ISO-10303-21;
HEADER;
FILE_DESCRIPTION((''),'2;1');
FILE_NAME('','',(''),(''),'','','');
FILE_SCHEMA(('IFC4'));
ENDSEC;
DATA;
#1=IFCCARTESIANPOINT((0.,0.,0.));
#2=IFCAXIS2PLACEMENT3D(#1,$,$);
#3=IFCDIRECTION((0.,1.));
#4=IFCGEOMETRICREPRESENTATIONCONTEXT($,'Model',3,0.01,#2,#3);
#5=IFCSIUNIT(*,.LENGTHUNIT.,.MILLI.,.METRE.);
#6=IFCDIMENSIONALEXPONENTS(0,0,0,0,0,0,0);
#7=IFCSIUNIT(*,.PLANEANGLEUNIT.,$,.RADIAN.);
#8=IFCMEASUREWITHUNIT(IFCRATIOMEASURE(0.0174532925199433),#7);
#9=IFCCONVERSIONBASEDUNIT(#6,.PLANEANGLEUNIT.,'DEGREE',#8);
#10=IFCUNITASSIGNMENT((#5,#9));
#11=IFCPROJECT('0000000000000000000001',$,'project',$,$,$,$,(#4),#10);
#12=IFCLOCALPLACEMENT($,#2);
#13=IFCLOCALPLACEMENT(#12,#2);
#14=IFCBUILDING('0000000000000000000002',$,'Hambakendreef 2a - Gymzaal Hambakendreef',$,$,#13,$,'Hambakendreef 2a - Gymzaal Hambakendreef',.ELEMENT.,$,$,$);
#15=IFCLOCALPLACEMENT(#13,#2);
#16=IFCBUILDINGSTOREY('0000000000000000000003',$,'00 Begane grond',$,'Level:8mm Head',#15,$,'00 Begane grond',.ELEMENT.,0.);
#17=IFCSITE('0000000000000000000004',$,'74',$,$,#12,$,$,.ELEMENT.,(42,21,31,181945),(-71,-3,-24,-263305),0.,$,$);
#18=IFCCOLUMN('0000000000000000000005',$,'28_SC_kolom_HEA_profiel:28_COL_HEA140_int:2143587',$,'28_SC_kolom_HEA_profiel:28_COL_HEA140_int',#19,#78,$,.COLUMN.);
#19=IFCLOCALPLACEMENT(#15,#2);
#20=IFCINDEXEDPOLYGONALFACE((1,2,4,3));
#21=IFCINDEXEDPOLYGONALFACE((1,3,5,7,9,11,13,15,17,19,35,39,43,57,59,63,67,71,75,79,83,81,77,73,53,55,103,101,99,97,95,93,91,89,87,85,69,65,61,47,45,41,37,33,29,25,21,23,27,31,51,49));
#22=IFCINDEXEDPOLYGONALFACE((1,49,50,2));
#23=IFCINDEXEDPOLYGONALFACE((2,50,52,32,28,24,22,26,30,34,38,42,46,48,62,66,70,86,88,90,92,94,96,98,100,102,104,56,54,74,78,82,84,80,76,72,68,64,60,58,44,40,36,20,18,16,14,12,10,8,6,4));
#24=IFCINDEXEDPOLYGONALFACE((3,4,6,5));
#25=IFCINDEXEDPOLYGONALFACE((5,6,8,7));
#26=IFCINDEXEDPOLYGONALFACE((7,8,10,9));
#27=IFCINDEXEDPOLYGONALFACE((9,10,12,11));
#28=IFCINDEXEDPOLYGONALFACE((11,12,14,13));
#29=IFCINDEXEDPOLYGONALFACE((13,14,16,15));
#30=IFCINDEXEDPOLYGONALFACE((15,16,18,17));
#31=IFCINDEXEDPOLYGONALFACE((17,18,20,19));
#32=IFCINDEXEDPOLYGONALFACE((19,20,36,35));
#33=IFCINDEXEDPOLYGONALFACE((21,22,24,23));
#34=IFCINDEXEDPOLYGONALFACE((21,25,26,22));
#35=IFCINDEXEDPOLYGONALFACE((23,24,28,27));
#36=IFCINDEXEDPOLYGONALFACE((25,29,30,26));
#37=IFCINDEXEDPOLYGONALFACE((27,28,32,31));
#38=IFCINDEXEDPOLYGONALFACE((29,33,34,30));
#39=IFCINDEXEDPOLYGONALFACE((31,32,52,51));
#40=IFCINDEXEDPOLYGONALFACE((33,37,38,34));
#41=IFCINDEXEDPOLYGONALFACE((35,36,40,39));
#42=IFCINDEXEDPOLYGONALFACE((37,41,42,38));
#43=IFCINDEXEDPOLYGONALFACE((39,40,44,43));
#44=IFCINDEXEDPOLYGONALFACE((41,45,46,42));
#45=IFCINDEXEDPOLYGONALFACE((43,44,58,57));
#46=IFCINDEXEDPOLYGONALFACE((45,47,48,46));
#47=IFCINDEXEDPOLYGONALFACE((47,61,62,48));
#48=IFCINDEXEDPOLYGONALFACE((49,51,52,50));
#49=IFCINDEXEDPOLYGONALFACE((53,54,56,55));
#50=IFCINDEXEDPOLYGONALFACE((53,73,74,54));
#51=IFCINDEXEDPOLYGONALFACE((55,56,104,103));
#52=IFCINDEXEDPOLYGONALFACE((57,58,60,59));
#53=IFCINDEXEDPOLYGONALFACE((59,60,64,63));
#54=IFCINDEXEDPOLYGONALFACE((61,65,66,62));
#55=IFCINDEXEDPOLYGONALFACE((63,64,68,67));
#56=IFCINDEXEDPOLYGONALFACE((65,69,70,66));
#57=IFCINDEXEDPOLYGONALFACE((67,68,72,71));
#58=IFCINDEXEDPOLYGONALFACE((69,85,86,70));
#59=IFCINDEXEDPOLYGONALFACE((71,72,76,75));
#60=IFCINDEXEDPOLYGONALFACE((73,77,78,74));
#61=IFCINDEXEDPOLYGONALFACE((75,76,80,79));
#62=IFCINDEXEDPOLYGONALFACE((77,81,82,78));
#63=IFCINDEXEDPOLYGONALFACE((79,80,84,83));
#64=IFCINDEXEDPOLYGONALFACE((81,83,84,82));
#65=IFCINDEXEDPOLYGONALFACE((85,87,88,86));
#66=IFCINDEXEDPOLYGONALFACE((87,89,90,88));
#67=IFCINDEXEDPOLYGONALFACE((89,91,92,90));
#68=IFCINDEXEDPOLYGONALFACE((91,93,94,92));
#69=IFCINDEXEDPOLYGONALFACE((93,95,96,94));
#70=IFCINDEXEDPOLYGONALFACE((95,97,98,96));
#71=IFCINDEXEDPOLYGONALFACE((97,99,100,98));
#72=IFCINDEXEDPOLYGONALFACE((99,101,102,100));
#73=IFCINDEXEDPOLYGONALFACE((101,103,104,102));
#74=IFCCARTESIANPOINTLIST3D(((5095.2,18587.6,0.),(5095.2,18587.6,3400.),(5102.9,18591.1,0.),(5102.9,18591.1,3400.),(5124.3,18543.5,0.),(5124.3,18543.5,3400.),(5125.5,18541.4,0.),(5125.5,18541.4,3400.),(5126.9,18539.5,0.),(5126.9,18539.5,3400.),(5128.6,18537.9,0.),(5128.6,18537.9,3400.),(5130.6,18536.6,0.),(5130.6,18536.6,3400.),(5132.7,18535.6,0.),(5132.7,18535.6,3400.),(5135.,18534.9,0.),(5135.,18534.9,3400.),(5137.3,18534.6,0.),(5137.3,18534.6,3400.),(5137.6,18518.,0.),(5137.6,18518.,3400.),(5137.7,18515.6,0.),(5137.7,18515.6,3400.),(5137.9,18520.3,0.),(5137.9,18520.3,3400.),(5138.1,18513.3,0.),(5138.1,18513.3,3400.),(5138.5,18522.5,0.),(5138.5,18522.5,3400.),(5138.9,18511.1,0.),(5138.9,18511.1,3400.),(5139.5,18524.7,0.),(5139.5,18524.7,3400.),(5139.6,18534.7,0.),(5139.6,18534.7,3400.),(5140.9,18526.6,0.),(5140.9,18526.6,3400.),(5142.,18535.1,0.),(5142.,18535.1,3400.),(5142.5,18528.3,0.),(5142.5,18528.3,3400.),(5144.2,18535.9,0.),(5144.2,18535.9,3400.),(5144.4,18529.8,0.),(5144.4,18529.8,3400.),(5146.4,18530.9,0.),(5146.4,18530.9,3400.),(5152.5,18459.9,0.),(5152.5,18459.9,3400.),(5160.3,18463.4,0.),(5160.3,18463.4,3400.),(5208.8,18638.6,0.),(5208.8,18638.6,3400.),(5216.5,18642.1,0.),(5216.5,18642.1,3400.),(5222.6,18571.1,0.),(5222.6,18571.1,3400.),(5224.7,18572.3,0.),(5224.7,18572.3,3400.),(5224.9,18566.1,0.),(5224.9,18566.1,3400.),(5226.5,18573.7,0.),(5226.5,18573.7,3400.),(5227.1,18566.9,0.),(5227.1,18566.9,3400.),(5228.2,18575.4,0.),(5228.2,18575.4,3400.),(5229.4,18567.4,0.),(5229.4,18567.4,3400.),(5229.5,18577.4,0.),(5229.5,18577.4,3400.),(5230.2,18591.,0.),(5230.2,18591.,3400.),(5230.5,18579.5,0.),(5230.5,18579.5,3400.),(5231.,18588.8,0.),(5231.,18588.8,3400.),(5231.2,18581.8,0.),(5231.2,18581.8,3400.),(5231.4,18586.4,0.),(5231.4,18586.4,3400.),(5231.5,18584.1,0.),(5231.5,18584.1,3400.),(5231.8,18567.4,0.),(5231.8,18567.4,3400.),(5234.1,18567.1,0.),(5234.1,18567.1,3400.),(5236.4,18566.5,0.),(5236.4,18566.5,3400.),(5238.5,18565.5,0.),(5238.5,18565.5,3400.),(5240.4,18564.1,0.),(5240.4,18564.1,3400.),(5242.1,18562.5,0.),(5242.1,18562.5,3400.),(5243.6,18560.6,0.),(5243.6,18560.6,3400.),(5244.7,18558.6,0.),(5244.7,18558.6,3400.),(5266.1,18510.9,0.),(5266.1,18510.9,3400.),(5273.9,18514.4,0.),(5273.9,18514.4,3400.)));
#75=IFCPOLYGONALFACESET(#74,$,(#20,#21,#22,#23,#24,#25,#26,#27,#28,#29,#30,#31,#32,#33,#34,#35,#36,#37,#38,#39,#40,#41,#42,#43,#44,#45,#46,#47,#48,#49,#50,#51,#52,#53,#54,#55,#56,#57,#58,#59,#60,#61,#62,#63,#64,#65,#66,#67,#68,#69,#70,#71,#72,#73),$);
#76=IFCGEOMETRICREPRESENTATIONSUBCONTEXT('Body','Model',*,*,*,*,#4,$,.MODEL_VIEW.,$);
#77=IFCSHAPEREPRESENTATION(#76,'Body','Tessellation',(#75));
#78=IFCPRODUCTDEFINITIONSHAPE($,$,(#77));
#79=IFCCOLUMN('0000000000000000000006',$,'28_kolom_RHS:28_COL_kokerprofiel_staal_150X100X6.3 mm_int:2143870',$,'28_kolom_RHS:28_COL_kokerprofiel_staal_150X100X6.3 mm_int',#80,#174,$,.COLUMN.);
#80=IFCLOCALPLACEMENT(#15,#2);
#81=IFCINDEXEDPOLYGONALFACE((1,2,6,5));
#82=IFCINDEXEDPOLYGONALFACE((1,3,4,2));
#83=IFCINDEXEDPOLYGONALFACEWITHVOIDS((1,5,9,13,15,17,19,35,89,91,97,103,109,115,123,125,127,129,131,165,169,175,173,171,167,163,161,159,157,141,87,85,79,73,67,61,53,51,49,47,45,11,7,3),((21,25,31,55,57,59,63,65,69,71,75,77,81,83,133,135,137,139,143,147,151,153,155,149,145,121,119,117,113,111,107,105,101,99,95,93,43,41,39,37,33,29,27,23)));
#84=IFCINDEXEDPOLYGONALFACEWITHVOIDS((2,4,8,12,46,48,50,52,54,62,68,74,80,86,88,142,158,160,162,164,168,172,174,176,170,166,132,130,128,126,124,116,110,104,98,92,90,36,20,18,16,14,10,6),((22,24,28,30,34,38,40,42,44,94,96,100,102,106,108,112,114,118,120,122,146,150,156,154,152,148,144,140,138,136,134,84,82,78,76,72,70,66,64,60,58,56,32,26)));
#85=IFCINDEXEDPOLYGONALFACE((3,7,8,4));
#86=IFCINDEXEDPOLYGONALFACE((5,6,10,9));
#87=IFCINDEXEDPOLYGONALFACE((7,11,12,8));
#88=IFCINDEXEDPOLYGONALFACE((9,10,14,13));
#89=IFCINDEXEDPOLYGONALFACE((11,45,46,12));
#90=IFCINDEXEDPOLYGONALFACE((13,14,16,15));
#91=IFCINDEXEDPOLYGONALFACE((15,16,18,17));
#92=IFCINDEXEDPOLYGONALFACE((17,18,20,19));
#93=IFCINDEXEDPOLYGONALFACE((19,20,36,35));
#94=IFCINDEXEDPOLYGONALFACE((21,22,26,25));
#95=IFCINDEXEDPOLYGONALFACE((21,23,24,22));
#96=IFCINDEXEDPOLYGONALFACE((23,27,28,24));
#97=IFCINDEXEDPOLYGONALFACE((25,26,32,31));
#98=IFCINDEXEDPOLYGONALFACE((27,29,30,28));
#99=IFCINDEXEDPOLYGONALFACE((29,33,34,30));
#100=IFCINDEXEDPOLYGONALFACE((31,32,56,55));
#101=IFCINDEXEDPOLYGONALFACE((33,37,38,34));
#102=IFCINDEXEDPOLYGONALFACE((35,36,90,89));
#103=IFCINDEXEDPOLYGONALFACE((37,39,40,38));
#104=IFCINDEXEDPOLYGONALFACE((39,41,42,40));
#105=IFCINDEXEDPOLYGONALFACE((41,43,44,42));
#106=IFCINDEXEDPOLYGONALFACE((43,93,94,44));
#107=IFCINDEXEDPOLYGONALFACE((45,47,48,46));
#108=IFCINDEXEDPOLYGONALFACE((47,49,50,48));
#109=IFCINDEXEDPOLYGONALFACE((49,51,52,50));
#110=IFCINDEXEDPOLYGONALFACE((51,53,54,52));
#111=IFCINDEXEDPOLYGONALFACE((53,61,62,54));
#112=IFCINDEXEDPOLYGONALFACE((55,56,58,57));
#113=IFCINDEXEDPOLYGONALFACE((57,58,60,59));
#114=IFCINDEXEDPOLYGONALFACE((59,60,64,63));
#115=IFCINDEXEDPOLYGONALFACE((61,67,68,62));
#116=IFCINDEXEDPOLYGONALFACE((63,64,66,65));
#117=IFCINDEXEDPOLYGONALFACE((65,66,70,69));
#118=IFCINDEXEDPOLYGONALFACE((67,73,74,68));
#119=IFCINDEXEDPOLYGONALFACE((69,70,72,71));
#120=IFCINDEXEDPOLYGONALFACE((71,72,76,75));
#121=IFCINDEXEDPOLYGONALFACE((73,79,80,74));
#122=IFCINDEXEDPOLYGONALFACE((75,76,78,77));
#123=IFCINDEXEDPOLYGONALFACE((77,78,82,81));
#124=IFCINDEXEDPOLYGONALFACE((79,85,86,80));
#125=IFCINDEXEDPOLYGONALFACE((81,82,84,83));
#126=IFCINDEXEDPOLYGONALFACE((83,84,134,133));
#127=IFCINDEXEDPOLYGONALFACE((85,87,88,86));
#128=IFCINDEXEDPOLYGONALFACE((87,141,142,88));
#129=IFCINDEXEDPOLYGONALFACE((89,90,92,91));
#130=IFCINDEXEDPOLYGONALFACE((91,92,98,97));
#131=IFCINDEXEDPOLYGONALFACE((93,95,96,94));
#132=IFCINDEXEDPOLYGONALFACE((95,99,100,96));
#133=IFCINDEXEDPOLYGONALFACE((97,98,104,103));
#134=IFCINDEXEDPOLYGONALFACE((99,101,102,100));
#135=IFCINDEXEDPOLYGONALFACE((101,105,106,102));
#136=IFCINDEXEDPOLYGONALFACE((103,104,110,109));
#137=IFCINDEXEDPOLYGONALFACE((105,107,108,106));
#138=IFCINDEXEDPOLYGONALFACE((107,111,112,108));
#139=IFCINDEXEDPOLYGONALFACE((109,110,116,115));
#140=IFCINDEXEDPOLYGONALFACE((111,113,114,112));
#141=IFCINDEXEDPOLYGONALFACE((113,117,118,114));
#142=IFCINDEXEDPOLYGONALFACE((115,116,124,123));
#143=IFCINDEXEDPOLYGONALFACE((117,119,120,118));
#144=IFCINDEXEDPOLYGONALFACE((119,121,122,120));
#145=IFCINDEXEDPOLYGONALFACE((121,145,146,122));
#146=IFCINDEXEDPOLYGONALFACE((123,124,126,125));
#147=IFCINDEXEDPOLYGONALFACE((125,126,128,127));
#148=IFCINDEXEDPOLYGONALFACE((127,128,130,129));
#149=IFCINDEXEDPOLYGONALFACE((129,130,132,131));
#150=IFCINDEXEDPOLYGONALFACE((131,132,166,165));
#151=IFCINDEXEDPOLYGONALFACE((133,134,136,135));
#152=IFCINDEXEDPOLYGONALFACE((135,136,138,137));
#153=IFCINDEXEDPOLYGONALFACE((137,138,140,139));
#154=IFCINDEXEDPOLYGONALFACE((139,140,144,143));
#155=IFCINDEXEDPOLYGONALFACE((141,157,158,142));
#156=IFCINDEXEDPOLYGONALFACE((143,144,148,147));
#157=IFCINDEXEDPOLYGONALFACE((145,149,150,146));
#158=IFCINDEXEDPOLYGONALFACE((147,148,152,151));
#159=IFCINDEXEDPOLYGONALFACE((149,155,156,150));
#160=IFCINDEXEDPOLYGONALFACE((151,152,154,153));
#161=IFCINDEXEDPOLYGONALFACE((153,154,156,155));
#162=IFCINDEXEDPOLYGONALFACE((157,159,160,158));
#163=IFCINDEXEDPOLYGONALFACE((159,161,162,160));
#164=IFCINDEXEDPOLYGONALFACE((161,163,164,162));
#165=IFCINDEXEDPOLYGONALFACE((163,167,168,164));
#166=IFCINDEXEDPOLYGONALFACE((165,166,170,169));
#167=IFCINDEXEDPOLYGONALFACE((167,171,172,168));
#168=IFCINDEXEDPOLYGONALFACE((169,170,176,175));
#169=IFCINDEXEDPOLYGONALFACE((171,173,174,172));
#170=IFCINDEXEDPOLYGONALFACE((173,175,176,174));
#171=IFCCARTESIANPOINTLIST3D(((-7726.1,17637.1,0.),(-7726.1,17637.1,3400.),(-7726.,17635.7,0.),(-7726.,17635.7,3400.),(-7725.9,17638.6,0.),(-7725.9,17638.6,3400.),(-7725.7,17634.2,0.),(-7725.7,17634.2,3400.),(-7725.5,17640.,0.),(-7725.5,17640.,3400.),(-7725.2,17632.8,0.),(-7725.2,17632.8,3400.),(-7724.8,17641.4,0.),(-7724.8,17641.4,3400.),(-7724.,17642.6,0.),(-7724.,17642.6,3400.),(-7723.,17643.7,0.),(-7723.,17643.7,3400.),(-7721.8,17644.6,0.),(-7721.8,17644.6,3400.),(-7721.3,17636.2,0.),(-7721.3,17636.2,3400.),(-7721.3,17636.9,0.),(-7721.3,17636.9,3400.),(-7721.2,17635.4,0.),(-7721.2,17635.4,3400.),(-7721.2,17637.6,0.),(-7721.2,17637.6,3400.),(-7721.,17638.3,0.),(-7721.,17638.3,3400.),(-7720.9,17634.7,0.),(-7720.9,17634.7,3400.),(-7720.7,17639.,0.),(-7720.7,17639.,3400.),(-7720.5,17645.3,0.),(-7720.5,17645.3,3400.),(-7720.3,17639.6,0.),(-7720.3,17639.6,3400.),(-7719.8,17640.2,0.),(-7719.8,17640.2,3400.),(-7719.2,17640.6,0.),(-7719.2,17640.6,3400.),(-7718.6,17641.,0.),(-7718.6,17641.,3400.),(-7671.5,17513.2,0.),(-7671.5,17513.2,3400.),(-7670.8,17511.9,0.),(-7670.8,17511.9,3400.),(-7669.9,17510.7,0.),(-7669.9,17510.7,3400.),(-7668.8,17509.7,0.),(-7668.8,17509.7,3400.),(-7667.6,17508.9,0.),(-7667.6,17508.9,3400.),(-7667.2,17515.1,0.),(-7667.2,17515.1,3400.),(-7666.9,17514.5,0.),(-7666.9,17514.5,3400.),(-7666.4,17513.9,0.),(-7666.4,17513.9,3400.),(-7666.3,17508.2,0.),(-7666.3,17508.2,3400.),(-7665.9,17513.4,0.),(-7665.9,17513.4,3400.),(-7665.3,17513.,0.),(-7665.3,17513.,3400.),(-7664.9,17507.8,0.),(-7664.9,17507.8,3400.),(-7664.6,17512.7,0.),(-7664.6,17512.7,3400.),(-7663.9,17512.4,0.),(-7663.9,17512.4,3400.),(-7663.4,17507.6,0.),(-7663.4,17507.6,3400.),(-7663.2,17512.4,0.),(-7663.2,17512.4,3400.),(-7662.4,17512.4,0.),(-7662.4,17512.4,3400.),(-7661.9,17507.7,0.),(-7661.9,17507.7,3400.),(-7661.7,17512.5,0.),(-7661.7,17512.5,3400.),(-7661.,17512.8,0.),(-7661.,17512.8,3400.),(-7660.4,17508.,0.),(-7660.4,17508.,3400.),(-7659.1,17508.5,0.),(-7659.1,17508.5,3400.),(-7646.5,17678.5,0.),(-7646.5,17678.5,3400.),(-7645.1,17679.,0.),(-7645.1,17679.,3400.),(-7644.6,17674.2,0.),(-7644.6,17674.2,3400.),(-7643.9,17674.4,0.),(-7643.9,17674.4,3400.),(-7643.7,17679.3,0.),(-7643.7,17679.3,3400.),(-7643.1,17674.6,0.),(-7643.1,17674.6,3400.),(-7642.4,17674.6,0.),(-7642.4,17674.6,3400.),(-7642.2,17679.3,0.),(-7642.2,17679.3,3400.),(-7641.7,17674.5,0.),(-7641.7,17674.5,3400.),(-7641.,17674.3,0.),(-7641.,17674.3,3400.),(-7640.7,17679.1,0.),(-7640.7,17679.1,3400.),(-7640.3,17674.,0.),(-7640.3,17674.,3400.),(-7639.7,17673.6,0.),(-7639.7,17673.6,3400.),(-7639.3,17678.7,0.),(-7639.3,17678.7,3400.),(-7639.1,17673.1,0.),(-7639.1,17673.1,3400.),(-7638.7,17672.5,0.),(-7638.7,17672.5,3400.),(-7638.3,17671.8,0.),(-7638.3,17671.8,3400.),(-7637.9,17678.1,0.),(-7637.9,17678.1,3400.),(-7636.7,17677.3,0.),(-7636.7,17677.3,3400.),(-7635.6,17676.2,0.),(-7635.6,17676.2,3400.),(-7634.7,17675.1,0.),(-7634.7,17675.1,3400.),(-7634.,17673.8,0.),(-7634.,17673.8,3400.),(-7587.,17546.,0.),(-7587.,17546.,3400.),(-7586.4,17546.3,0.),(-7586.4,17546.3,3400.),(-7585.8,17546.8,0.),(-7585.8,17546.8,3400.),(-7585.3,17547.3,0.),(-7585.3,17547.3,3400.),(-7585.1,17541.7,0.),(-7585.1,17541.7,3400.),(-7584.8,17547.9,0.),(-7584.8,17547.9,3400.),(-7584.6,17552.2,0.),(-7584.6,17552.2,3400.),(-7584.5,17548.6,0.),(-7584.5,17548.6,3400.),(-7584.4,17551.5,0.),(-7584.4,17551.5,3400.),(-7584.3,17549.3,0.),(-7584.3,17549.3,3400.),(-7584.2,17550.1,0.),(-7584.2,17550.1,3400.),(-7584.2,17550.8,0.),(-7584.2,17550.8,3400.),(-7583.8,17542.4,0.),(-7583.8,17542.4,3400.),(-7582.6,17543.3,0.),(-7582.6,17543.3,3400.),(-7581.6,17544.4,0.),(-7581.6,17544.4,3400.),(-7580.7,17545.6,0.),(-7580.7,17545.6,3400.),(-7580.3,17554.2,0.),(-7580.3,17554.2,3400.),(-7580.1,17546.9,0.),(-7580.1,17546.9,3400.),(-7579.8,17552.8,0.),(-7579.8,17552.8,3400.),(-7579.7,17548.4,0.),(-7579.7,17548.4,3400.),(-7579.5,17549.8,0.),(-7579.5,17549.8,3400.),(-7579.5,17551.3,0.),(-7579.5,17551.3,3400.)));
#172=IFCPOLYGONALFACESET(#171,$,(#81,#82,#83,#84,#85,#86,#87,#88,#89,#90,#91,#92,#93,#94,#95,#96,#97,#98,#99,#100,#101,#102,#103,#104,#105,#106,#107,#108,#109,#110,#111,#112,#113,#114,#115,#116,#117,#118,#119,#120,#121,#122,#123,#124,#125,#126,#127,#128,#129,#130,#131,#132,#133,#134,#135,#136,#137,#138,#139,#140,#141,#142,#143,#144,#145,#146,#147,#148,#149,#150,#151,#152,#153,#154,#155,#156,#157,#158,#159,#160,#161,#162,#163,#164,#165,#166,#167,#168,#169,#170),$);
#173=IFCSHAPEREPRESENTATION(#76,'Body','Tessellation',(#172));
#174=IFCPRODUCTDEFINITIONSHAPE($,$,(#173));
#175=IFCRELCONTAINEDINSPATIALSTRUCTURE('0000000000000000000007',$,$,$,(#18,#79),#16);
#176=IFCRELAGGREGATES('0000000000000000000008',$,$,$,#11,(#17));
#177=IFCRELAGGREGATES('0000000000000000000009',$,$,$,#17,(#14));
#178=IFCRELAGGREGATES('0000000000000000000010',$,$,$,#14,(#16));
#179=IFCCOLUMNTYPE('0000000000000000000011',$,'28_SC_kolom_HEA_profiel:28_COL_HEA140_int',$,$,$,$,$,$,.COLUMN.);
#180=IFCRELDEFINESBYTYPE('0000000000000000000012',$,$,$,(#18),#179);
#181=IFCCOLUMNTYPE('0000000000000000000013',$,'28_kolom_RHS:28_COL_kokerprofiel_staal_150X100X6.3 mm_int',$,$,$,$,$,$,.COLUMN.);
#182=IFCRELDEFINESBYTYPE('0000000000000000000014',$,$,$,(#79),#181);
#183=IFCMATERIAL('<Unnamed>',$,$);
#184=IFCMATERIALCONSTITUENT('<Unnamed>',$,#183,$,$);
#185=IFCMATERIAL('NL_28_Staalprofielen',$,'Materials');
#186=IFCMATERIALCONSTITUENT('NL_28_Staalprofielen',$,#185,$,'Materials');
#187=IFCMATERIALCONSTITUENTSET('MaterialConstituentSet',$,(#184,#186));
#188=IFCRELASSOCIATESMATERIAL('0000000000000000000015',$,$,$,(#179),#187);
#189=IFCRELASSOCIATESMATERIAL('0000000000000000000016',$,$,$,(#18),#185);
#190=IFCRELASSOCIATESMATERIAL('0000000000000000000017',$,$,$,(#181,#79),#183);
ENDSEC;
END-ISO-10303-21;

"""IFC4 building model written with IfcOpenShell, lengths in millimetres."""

from ifc_helpers import new_model, entity, si_unit, converted_unit, direction, frame, origin, place, context, subcontext, project, spatial, indexed_curve, outline, extrude, source, transform, mapped, material, constituent, constituent_set, type_object, type_shapes, element, save


model = new_model("IFC4")

# Units and contexts
model_context = context("Model", 3, precision=0.01, world=origin(), true_north=direction((0.0, 1.0)))
body_context = subcontext(model_context, "Body", "Model", "MODEL_VIEW")
ifc_project = project(units=[si_unit("LENGTHUNIT", "METRE", prefix="MILLI"), converted_unit("PLANEANGLEUNIT", "DEGREE", entity("IfcRatioMeasure", 0.0174532925199433), si_unit("PLANEANGLEUNIT", "RADIAN"), dimensions=[0, 0, 0, 0, 0, 0, 0])], contexts=[model_context])

# Site, building, storey
site_placement = place(None, origin())
site = spatial("IfcSite", under=ifc_project, at=site_placement, Name="74", CompositionType="ELEMENT", RefLatitude=(42, 21, 31, 181945), RefLongitude=(-71, -3, -24, -263305), RefElevation=0.0)
building_placement = place(site_placement, origin())
building = spatial("IfcBuilding", under=site, at=building_placement, Name="Hambakendreef 2a - Gymzaal Hambakendreef", LongName="Hambakendreef 2a - Gymzaal Hambakendreef", CompositionType="ELEMENT")
storey_placement = place(building_placement, origin())
storey = spatial("IfcBuildingStorey", under=building, at=storey_placement, Name="00 Begane grond", ObjectType="Level:8mm Head", LongName="00 Begane grond", CompositionType="ELEMENT", Elevation=0.0)

# Columns
ifc_material_1 = material(Name="NL_28_Staalprofielen", Category="Materials")
ifc_material_2 = material(Name="<Unnamed>")
ifc_constituent_1 = constituent(ifc_material_2, Name="<Unnamed>")
ifc_constituent_2 = constituent(ifc_material_1, Name="NL_28_Staalprofielen", Category="Materials")
ifc_constituent_set_1 = constituent_set(constituents=[ifc_constituent_1, ifc_constituent_2], Name="MaterialConstituentSet")
column_type_1 = type_object("IfcColumnType", Name="28_SC_kolom_HEA_profiel:28_COL_HEA140_int", PredefinedType="COLUMN", material=ifc_constituent_set_1)
shared_shape_1 = source(origin(), body_context, "Body", "SweptSolid", [
    extrude(outline(indexed_curve([(58.0, -70.0), (66.5, -70.0), (66.5, 70.0), (58.0, 70.0), (58.0, 17.8), (57.8, 15.4), (57.3, 13.1), (56.4, 10.9), (55.1, 8.9), (53.6, 7.1), (51.8, 5.6), (49.8, 4.4), (47.6, 3.5), (45.3, 2.9), (43.0, 2.8), (-43.0, 2.8), (-45.3, 2.9), (-47.6, 3.5), (-49.8, 4.4), (-51.8, 5.6), (-53.6, 7.1), (-55.1, 8.9), (-56.4, 10.9), (-57.3, 13.1), (-57.8, 15.4), (-58.0, 17.7), (-58.0, 70.0), (-66.5, 70.0), (-66.5, -70.0), (-58.0, -70.0), (-58.0, -17.8), (-57.8, -15.4), (-57.3, -13.1), (-56.4, -10.9), (-55.1, -8.9), (-53.6, -7.1), (-51.8, -5.6), (-49.8, -4.4), (-47.6, -3.5), (-45.3, -2.9), (-43.0, -2.7), (43.0, -2.8), (45.3, -2.9), (47.6, -3.5), (49.8, -4.4), (51.8, -5.6), (53.6, -7.1), (55.1, -8.9), (56.4, -10.9), (57.3, -13.1), (57.8, -15.4), (58.0, -17.8), (58.0, -70.0)], self_intersect=False)), frame((0.0, 0.0, 0.0), z_axis=(0.0, 0.0, 1.0), x_axis=(0.0, -1.0, 0.0)), (0.0, 0.0, 1.0), 3400.0),
])
type_shapes(column_type_1, [shared_shape_1])
column_placement = place(storey_placement, frame((5184.5, 18551.0, 0.0), z_axis=(0.0, 0.0, 1.0), x_axis=(0.40959, -0.91227, 0.0)))
element("IfcColumn", 1, at=column_placement, inside=storey, type_object=column_type_1, material=ifc_material_1, Name="28_SC_kolom_HEA_profiel:28_COL_HEA140_int:2143587", ObjectType="28_SC_kolom_HEA_profiel:28_COL_HEA140_int", PredefinedType="COLUMN", context=body_context, shape_type="MappedRepresentation", body=[
    mapped(shared_shape_1, transform((0.0, 0.0, 0.0), scale=1.0)),
])
column_type_2 = type_object("IfcColumnType", Name="28_kolom_RHS:28_COL_kokerprofiel_staal_150X100X6.3 mm_int", PredefinedType="COLUMN", material=ifc_material_2)
shared_shape_2 = source(origin(), body_context, "Body", "SweptSolid", [
    extrude(outline(indexed_curve([(-40.5, -75.0), (40.5, -75.0), (42.0, -74.9), (43.5, -74.5), (44.8, -74.0), (46.1, -73.2), (47.2, -72.2), (48.2, -71.1), (49.0, -69.8), (49.5, -68.5), (49.9, -67.0), (50.0, -65.6), (50.0, 65.6), (49.9, 67.0), (49.5, 68.5), (49.0, 69.8), (48.2, 71.1), (47.2, 72.2), (46.1, 73.2), (44.8, 74.0), (43.5, 74.5), (42.0, 74.9), (40.5, 75.0), (-40.5, 75.0), (-42.0, 74.9), (-43.5, 74.5), (-44.8, 74.0), (-46.1, 73.2), (-47.2, 72.2), (-48.2, 71.1), (-49.0, 69.8), (-49.5, 68.5), (-49.9, 67.0), (-50.0, 65.6), (-50.0, -65.6), (-49.9, -67.0), (-49.5, -68.5), (-49.0, -69.8), (-48.2, -71.1), (-47.2, -72.2), (-46.1, -73.2), (-44.8, -74.0), (-43.5, -74.5), (-42.0, -74.9), (-40.5, -75.0)], self_intersect=False), holes=[indexed_curve([(-45.3, 65.5), (-45.2, 66.3), (-45.0, 67.0), (-44.8, 67.7), (-44.4, 68.3), (-43.9, 68.9), (-43.3, 69.4), (-42.7, 69.8), (-42.0, 70.0), (-41.3, 70.2), (-40.6, 70.3), (40.5, 70.3), (41.3, 70.2), (42.0, 70.0), (42.7, 69.8), (43.3, 69.4), (43.9, 68.9), (44.4, 68.3), (44.8, 67.7), (45.0, 67.0), (45.2, 66.3), (45.3, 65.5), (45.3, -65.5), (45.2, -66.3), (45.0, -67.0), (44.8, -67.7), (44.4, -68.3), (43.9, -68.9), (43.3, -69.4), (42.7, -69.8), (42.0, -70.0), (41.3, -70.2), (40.5, -70.3), (-40.6, -70.3), (-41.3, -70.2), (-42.0, -70.0), (-42.7, -69.8), (-43.3, -69.4), (-43.9, -68.9), (-44.4, -68.3), (-44.8, -67.7), (-45.0, -67.0), (-45.2, -66.3), (-45.3, -65.5), (-45.3, 65.5)], self_intersect=False)]), frame((235.6, 34.3, 0.0), z_axis=(0.0, 0.0, 1.0), x_axis=(0.0, 1.0, 0.0)), (0.0, 0.0, 1.0), 3400.0),
])
type_shapes(column_type_2, [shared_shape_2])
for number, where, z_axis, x_axis, name in (
    (2, (-7780.5, 17794.4, 0.0), (0.0, 0.0, 1.0), (0.40959, -0.91227, 0.0), "28_kolom_RHS:28_COL_kokerprofiel_staal_150X100X6.3 mm_int:2143870"),
):
    element("IfcColumn", number, at=place(storey_placement, frame(where, z_axis=z_axis, x_axis=x_axis)), inside=storey, type_object=column_type_2, material=ifc_material_2, Name=name, ObjectType="28_kolom_RHS:28_COL_kokerprofiel_staal_150X100X6.3 mm_int", PredefinedType="COLUMN", context=body_context, shape_type="MappedRepresentation", body=[
        mapped(shared_shape_2, transform((0.0, 0.0, 0.0), scale=1.0)),
    ])

save(model, "model.ifc")
